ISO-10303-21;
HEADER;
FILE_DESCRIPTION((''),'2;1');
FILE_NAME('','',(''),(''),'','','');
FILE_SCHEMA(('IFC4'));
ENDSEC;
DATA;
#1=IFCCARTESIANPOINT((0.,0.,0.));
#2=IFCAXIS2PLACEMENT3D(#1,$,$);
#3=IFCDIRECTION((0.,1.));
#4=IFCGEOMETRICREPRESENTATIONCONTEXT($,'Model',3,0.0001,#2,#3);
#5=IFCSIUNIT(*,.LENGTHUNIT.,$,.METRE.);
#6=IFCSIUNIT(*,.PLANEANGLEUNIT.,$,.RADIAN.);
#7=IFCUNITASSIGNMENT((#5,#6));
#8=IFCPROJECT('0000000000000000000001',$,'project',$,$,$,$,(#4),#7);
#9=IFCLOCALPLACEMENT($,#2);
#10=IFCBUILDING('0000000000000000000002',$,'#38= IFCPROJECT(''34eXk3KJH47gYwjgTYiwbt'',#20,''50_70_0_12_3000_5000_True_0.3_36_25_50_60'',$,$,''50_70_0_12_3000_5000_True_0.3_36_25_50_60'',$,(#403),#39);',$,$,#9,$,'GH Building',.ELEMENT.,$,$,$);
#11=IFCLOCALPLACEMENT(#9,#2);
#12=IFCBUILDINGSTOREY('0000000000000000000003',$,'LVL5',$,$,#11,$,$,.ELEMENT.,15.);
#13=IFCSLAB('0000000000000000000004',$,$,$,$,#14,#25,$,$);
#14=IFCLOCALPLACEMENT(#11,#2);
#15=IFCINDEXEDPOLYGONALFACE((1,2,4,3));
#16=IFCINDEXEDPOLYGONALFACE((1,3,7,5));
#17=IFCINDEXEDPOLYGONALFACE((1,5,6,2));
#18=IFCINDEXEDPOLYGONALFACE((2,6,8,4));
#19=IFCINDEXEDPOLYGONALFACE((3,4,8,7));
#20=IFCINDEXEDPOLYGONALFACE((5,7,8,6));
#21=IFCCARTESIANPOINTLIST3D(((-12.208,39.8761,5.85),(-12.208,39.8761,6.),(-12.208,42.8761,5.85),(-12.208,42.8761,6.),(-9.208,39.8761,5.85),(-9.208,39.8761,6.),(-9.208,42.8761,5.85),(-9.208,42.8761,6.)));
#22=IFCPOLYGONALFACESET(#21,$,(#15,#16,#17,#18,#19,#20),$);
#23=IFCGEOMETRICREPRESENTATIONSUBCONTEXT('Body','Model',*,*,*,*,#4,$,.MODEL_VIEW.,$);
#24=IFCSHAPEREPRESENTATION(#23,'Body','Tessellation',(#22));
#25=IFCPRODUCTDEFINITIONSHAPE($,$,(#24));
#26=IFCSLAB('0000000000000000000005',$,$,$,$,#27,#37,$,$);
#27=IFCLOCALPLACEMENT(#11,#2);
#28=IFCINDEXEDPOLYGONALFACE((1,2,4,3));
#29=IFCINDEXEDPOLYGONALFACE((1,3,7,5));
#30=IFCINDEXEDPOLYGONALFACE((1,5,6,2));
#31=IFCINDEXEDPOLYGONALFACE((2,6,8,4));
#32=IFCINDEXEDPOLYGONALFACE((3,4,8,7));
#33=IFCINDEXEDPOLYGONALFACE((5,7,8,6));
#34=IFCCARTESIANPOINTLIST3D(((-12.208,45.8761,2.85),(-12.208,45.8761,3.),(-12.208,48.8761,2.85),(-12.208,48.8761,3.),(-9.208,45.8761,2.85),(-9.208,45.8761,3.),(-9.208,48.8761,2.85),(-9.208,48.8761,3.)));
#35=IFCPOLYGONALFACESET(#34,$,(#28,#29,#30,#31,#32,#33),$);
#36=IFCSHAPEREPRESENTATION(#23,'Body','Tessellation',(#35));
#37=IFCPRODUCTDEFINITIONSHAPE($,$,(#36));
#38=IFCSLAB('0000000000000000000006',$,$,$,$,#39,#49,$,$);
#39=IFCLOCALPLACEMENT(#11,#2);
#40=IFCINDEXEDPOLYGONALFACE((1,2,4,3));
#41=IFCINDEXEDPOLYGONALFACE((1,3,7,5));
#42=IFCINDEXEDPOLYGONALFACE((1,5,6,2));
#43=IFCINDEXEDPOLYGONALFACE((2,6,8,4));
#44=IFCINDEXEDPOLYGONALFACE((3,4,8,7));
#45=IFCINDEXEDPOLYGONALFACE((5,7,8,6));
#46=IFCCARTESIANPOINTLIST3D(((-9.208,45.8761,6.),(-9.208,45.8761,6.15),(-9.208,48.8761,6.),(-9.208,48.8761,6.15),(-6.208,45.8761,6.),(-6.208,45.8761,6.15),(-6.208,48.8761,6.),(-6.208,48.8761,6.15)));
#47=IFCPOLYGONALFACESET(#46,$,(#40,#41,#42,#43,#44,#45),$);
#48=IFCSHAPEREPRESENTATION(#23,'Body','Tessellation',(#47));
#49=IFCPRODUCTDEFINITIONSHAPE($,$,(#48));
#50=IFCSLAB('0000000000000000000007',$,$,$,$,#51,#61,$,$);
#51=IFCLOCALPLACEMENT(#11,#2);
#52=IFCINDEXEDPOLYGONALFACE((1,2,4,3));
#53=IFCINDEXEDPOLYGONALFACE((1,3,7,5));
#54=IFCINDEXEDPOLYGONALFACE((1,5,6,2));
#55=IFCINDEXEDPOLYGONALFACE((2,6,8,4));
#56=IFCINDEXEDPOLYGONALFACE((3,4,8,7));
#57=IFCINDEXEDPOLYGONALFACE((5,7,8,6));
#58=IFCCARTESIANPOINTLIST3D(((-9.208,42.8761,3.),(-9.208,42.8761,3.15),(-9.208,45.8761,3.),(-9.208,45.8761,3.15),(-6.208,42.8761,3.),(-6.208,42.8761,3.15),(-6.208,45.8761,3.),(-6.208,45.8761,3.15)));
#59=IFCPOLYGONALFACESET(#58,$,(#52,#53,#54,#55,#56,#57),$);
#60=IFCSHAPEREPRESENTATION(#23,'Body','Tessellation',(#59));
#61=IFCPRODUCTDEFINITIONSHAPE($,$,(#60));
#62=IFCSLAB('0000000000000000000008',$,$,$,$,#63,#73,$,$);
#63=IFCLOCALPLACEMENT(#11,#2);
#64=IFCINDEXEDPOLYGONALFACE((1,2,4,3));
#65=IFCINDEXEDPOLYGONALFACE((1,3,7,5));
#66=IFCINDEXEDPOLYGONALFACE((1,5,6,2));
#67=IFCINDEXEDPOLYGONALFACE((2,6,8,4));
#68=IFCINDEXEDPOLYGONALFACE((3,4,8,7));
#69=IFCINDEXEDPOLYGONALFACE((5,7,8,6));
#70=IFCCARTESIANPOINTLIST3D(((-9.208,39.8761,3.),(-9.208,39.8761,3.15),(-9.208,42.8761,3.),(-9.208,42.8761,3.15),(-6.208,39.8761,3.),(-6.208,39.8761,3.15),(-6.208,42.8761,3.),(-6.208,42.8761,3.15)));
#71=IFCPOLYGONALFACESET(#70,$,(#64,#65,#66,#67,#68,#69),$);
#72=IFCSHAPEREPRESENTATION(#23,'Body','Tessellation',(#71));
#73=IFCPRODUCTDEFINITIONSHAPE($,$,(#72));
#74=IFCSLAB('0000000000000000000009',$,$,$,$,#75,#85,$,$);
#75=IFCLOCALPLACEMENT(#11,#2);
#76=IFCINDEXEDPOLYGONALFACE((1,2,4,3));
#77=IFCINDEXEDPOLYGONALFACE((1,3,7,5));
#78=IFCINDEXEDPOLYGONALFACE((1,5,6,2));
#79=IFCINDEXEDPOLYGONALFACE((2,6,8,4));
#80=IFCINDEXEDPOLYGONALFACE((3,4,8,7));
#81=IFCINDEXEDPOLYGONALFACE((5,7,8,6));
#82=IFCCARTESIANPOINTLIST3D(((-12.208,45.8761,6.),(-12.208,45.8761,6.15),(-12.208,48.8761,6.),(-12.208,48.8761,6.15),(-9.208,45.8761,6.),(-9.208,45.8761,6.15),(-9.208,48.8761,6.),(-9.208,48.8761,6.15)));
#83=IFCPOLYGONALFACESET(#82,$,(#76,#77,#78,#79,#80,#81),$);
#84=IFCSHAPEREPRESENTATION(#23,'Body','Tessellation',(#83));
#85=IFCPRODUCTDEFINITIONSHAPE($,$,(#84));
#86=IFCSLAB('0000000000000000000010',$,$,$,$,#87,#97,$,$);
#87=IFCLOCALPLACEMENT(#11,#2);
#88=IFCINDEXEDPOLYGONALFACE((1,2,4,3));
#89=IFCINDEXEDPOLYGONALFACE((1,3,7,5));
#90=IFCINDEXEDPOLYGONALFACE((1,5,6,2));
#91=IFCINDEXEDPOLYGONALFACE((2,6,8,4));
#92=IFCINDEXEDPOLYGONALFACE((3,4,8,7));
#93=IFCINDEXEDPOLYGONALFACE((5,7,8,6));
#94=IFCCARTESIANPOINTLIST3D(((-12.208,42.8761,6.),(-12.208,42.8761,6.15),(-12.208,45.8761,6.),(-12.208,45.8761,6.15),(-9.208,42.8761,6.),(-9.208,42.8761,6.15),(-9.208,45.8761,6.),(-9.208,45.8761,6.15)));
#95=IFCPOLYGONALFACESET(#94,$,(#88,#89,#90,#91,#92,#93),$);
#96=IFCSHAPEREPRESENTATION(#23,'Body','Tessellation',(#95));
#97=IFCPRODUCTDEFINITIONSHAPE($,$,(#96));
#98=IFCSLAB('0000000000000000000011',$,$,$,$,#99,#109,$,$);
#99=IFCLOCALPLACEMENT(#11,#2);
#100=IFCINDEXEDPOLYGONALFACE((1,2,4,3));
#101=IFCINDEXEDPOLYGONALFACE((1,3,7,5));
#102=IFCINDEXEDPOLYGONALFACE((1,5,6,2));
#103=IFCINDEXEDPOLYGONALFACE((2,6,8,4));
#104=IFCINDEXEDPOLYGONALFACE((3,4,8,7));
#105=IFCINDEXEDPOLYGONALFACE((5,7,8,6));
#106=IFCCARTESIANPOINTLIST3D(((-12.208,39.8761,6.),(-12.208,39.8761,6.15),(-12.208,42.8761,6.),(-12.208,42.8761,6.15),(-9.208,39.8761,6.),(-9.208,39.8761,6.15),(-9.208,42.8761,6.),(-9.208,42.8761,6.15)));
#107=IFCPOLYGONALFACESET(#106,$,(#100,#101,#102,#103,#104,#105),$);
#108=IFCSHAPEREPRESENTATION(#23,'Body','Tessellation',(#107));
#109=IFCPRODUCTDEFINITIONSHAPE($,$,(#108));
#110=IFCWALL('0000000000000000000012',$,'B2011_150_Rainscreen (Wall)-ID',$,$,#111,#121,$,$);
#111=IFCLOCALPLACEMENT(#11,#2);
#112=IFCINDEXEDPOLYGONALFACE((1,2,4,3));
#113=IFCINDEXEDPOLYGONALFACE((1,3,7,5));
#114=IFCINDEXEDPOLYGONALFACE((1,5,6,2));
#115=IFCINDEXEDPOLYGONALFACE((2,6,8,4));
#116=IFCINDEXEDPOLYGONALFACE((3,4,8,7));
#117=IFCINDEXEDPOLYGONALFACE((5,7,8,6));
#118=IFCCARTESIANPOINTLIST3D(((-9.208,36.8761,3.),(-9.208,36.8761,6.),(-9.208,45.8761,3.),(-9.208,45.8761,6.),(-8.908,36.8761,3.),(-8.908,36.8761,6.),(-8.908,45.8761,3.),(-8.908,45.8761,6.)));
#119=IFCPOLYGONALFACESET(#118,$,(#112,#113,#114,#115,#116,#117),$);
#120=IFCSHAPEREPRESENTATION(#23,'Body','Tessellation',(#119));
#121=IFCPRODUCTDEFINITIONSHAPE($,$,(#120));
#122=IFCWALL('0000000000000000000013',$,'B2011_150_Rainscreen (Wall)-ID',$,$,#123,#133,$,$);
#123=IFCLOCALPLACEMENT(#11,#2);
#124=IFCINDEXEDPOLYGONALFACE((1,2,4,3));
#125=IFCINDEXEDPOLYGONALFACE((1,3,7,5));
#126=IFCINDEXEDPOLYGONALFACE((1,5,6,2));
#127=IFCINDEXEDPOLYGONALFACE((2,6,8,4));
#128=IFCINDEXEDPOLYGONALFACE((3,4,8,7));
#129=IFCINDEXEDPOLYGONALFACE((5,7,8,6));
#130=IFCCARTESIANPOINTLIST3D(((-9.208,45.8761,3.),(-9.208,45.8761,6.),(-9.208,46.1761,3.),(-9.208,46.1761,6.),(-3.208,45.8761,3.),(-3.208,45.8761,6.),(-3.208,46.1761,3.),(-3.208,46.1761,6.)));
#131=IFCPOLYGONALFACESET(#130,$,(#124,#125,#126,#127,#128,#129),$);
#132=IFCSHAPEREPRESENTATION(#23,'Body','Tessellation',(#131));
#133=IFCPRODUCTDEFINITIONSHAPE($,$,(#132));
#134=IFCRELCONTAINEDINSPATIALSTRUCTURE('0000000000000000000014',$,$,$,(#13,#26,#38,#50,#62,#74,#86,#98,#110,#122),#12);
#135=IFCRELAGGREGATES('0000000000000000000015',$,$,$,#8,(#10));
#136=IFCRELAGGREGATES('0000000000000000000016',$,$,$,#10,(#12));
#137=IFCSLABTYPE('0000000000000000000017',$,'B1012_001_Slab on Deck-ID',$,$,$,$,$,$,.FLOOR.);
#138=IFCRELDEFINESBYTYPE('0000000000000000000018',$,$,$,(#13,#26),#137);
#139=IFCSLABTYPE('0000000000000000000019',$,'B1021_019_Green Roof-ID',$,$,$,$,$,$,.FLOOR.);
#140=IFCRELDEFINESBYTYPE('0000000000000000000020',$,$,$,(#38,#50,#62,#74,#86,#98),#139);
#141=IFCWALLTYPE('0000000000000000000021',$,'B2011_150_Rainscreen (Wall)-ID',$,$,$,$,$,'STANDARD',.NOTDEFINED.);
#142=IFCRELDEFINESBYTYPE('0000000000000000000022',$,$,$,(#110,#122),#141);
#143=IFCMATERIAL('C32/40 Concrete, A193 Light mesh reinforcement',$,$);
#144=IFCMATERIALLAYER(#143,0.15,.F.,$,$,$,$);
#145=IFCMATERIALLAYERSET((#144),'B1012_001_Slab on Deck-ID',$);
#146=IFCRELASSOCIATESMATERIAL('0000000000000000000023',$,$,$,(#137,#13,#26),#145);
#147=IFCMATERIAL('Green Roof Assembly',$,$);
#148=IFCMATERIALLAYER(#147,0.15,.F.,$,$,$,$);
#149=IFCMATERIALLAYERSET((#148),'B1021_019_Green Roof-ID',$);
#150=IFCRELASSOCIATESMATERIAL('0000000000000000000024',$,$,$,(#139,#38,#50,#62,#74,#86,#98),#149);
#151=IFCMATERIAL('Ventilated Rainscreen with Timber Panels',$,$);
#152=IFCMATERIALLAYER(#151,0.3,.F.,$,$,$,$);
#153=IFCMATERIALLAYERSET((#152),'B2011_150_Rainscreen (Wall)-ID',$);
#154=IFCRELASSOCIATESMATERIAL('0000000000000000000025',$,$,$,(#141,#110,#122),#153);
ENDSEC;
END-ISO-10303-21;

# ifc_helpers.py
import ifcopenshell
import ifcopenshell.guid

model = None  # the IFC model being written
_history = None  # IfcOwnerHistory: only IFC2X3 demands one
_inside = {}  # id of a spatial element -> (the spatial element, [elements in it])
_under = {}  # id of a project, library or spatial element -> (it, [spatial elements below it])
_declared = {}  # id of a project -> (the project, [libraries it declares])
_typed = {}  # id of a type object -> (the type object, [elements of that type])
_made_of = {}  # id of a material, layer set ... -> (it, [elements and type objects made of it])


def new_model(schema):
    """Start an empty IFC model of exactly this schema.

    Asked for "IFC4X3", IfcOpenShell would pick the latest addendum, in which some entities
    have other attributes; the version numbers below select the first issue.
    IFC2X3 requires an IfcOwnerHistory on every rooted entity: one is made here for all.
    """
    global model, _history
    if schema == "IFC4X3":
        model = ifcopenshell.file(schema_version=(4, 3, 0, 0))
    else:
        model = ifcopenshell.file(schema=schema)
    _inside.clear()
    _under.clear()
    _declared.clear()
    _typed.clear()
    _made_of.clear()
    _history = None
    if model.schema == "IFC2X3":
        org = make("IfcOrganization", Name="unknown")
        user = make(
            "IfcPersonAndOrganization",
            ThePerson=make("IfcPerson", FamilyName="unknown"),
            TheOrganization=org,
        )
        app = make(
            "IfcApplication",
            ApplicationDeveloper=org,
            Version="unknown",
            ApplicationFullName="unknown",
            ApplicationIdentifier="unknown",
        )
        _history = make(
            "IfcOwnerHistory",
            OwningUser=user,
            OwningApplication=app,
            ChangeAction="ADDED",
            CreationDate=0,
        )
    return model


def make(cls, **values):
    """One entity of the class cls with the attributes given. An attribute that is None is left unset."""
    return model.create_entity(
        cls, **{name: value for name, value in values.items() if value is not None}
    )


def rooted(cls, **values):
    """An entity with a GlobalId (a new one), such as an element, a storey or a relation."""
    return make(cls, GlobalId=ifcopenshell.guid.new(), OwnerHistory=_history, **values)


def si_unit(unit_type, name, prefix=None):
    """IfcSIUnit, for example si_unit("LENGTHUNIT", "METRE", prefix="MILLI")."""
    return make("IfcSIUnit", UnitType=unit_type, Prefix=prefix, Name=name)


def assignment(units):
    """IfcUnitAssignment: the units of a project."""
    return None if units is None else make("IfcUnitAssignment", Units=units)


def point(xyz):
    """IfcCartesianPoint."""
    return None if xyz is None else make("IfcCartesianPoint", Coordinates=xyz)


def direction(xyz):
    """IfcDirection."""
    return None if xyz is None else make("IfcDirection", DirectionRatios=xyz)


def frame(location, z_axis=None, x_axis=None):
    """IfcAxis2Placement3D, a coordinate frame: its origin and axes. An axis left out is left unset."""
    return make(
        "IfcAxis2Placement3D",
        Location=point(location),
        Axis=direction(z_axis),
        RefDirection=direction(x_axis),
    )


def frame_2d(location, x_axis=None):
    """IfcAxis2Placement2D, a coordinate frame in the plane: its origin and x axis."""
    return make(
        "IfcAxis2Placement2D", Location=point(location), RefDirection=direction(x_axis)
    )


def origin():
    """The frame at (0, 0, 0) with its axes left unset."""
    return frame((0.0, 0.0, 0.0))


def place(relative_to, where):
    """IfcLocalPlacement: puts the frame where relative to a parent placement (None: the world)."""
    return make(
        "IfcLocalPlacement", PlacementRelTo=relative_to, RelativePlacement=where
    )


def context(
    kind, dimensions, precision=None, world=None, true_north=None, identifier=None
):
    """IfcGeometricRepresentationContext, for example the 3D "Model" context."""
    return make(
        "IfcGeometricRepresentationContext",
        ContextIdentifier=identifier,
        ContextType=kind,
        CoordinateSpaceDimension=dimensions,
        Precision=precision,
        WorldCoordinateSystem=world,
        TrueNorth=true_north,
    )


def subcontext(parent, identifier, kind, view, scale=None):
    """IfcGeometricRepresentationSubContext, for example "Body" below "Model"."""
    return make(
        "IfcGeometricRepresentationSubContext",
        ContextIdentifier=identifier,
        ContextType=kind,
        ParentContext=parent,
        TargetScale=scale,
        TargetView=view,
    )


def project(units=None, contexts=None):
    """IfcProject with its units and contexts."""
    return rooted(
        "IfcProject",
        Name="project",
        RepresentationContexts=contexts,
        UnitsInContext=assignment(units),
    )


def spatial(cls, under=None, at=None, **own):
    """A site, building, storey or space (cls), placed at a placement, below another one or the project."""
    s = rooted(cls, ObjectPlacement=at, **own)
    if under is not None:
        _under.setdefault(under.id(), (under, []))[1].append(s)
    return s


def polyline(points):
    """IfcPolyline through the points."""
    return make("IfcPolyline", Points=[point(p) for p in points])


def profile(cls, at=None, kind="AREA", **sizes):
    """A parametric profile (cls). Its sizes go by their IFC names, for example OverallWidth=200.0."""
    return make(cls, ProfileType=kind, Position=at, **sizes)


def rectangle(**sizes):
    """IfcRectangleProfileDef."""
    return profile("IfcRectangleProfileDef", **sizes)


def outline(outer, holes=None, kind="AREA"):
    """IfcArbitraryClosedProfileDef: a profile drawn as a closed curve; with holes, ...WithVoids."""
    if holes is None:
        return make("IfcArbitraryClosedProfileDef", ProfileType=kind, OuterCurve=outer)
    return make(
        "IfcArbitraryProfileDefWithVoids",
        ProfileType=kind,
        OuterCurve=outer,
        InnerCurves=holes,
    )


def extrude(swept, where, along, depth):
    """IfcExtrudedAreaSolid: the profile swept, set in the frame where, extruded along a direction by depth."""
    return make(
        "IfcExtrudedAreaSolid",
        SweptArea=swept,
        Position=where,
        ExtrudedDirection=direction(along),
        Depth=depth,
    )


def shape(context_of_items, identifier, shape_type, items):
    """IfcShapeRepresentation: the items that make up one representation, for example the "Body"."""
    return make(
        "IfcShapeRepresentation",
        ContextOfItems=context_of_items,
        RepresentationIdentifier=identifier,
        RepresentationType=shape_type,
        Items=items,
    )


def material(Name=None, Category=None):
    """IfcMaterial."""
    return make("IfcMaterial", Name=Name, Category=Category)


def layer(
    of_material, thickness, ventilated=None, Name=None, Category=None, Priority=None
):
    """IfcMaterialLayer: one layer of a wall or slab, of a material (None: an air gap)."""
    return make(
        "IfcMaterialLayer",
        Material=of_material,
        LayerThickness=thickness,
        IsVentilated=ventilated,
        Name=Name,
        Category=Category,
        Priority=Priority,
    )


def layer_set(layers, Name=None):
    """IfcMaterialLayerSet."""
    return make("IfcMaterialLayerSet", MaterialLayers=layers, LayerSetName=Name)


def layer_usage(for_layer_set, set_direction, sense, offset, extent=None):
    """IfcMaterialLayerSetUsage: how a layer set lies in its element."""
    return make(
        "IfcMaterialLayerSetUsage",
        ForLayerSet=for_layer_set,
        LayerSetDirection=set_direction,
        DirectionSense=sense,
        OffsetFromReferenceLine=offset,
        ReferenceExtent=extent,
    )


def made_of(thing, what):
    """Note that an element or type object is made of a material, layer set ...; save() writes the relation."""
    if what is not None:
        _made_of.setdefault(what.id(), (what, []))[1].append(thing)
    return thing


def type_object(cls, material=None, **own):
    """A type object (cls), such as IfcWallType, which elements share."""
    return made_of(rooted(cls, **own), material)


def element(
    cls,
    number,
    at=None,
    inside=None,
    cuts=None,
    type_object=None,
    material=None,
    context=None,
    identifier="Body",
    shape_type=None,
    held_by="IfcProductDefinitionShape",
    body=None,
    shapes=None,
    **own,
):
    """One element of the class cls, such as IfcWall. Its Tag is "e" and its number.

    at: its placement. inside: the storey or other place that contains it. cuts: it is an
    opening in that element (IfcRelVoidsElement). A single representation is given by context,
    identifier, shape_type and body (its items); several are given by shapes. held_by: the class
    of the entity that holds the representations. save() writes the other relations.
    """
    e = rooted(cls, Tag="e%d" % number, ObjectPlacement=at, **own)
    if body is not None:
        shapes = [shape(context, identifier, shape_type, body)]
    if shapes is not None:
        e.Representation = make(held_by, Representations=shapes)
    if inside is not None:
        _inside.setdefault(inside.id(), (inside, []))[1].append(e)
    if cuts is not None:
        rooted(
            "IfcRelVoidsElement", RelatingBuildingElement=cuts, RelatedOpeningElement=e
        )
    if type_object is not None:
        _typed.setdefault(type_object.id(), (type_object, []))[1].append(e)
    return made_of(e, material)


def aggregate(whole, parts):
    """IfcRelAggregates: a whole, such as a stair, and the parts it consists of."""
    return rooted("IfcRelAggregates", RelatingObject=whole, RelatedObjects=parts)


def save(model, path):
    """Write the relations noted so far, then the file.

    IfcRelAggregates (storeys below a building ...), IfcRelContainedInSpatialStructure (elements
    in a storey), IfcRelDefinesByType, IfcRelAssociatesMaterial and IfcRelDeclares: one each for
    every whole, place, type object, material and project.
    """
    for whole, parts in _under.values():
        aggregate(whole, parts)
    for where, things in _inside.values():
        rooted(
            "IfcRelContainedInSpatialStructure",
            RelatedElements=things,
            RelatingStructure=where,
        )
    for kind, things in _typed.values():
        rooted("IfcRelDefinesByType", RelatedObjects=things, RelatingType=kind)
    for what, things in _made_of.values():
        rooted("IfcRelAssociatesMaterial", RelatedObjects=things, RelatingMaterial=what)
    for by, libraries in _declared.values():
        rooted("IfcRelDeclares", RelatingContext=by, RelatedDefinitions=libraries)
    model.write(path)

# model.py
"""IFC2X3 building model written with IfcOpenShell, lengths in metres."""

from ifc_helpers import new_model, si_unit, direction, frame, frame_2d, origin, place, context, subcontext, project, spatial, polyline, rectangle, outline, extrude, material, layer, layer_set, layer_usage, type_object, element, save


model = new_model("IFC2X3")

# Units and contexts
model_context = context("Model", 3, precision=0.0001, world=origin(), true_north=direction((0.0, 1.0)))
body_context = subcontext(model_context, "Body", "Model", "MODEL_VIEW")
ifc_project = project(units=[si_unit("LENGTHUNIT", "METRE"), si_unit("PLANEANGLEUNIT", "RADIAN")], contexts=[model_context])

# Building, storey
building_placement = place(None, origin())
building = spatial("IfcBuilding", under=ifc_project, at=building_placement, Name="#38= IFCPROJECT('34eXk3KJH47gYwjgTYiwbt',#20,'50_70_0_12_3000_5000_True_0.3_36_25_50_60',$,$,'50_70_0_12_3000_5000_True_0.3_36_25_50_60',$,(#403),#39);", LongName="GH Building", CompositionType="ELEMENT")
storey_placement = place(building_placement, origin())
storey = spatial("IfcBuildingStorey", under=building, at=storey_placement, Name="LVL5", CompositionType="ELEMENT", Elevation=15.0)

# Slabs
ifc_material_1 = material(Name="C32/40 Concrete, A193 Light mesh reinforcement")
ifc_layer_1 = layer(ifc_material_1, 0.15, ventilated=False)
ifc_layer_set_1 = layer_set([ifc_layer_1], Name="B1012_001_Slab on Deck-ID")
slab_type_1 = type_object("IfcSlabType", Name="B1012_001_Slab on Deck-ID", PredefinedType="FLOOR", material=ifc_layer_set_1)
ifc_layer_usage_1 = layer_usage(ifc_layer_set_1, "AXIS3", "NEGATIVE", -0.15)
slab_1_placement = place(storey_placement, frame((-10.708, 41.3761, 5.85)))
element("IfcSlab", 1, at=slab_1_placement, inside=storey, type_object=slab_type_1, material=ifc_layer_usage_1, context=body_context, shape_type="SweptSolid", body=[
    extrude(outline(polyline([(1.5, 1.5), (1.5, -1.5), (-1.5, -1.5), (-1.5, 1.5), (1.5, 1.5)])), origin(), (0.0, 0.0, 1.0), 0.15),
])
ifc_layer_usage_2 = layer_usage(ifc_layer_set_1, "AXIS3", "NEGATIVE", -0.15)
slab_2_placement = place(storey_placement, frame((-10.708, 47.3761, 2.85), z_axis=(0.0, 0.0, 1.0), x_axis=(0.0, -1.0, 0.0)))
element("IfcSlab", 2, at=slab_2_placement, inside=storey, type_object=slab_type_1, material=ifc_layer_usage_2, context=body_context, shape_type="SweptSolid", body=[
    extrude(outline(polyline([(-1.5, -1.5), (1.5, -1.5), (1.5, 1.5), (-1.5, 1.5), (-1.5, -1.5)])), origin(), (0.0, 0.0, 1.0), 0.15),
])
ifc_material_2 = material(Name="Green Roof Assembly")
ifc_layer_2 = layer(ifc_material_2, 0.15, ventilated=False)
ifc_layer_set_2 = layer_set([ifc_layer_2], Name="B1021_019_Green Roof-ID")
ifc_layer_usage_3 = layer_usage(ifc_layer_set_2, "AXIS3", "NEGATIVE", -0.15)
slab_type_2 = type_object("IfcSlabType", Name="B1021_019_Green Roof-ID", PredefinedType="FLOOR", material=ifc_layer_set_2)
slab_3_placement = place(storey_placement, frame((-7.708, 47.3761, 6.0)))
element("IfcSlab", 3, at=slab_3_placement, inside=storey, type_object=slab_type_2, material=ifc_layer_usage_3, context=body_context, shape_type="SweptSolid", body=[
    extrude(outline(polyline([(1.5, -1.5), (-1.5, -1.5), (-1.5, 1.5), (1.5, 1.5), (1.5, -1.5)])), origin(), (0.0, 0.0, 1.0), 0.15),
])
ifc_layer_usage_4 = layer_usage(ifc_layer_set_2, "AXIS3", "NEGATIVE", -0.15)
slab_4_placement = place(storey_placement, frame((-7.708, 44.3761, 3.0), z_axis=(0.0, 0.0, 1.0), x_axis=(0.0, -1.0, 0.0)))
element("IfcSlab", 4, at=slab_4_placement, inside=storey, type_object=slab_type_2, material=ifc_layer_usage_4, context=body_context, shape_type="SweptSolid", body=[
    extrude(outline(polyline([(-1.5, -1.5), (1.5, -1.5), (1.5, 1.5), (-1.5, 1.5), (-1.5, -1.5)])), origin(), (0.0, 0.0, 1.0), 0.15),
])
ifc_layer_usage_5 = layer_usage(ifc_layer_set_2, "AXIS3", "NEGATIVE", -0.15)
slab_5_placement = place(storey_placement, frame((-7.708, 41.3761, 3.0), z_axis=(0.0, 0.0, 1.0), x_axis=(0.0, -1.0, 0.0)))
element("IfcSlab", 5, at=slab_5_placement, inside=storey, type_object=slab_type_2, material=ifc_layer_usage_5, context=body_context, shape_type="SweptSolid", body=[
    extrude(outline(polyline([(-1.5, -1.5), (1.5, -1.5), (1.5, 1.5), (-1.5, 1.5), (-1.5, -1.5)])), origin(), (0.0, 0.0, 1.0), 0.15),
])
ifc_layer_usage_6 = layer_usage(ifc_layer_set_2, "AXIS3", "NEGATIVE", -0.15)
slab_6_placement = place(storey_placement, frame((-10.708, 47.3761, 6.0)))
element("IfcSlab", 6, at=slab_6_placement, inside=storey, type_object=slab_type_2, material=ifc_layer_usage_6, context=body_context, shape_type="SweptSolid", body=[
    extrude(outline(polyline([(1.5, 1.5), (1.5, -1.5), (-1.5, -1.5), (-1.5, 1.5), (1.5, 1.5)])), origin(), (0.0, 0.0, 1.0), 0.15),
])
ifc_layer_usage_7 = layer_usage(ifc_layer_set_2, "AXIS3", "NEGATIVE", -0.15)
slab_7_placement = place(storey_placement, frame((-10.708, 44.3761, 6.0)))
element("IfcSlab", 7, at=slab_7_placement, inside=storey, type_object=slab_type_2, material=ifc_layer_usage_7, context=body_context, shape_type="SweptSolid", body=[
    extrude(outline(polyline([(1.5, 1.5), (1.5, -1.5), (-1.5, -1.5), (-1.5, 1.5), (1.5, 1.5)])), origin(), (0.0, 0.0, 1.0), 0.15),
])
ifc_layer_usage_8 = layer_usage(ifc_layer_set_2, "AXIS3", "NEGATIVE", -0.15)
slab_8_placement = place(storey_placement, frame((-10.708, 41.3761, 6.0)))
element("IfcSlab", 8, at=slab_8_placement, inside=storey, type_object=slab_type_2, material=ifc_layer_usage_8, context=body_context, shape_type="SweptSolid", body=[
    extrude(outline(polyline([(1.5, 1.5), (1.5, -1.5), (-1.5, -1.5), (-1.5, 1.5), (1.5, 1.5)])), origin(), (0.0, 0.0, 1.0), 0.15),
])

# Walls
ifc_material_3 = material(Name="Ventilated Rainscreen with Timber Panels")
ifc_layer_3 = layer(ifc_material_3, 0.3, ventilated=False)
ifc_layer_set_3 = layer_set([ifc_layer_3], Name="B2011_150_Rainscreen (Wall)-ID")
ifc_layer_usage_9 = layer_usage(ifc_layer_set_3, "AXIS2", "POSITIVE", 0.0)
wall_type = type_object("IfcWallType", Name="B2011_150_Rainscreen (Wall)-ID", ElementType="STANDARD", PredefinedType="NOTDEFINED", material=ifc_layer_set_3)
wall_1_placement = place(storey_placement, frame((-9.208, 45.8761, 3.0), z_axis=(0.0, 0.0, 1.0), x_axis=(0.0, -1.0, 0.0)))
element("IfcWall", 9, at=wall_1_placement, inside=storey, type_object=wall_type, material=ifc_layer_usage_9, Name="B2011_150_Rainscreen (Wall)-ID", context=body_context, shape_type="SweptSolid", body=[
    extrude(rectangle(XDim=9.0, YDim=0.3, at=frame_2d((4.5, 0.15))), origin(), (0.0, 0.0, 1.0), 3.0),
])
ifc_layer_usage_10 = layer_usage(ifc_layer_set_3, "AXIS2", "POSITIVE", 0.0)
wall_2_placement = place(storey_placement, frame((-9.208, 45.8761, 3.0)))
element("IfcWall", 10, at=wall_2_placement, inside=storey, type_object=wall_type, material=ifc_layer_usage_10, Name="B2011_150_Rainscreen (Wall)-ID", context=body_context, shape_type="SweptSolid", body=[
    extrude(rectangle(XDim=6.0, YDim=0.3, at=frame_2d((3.0, 0.15))), origin(), (0.0, 0.0, 1.0), 3.0),
])

save(model, "model.ifc")
